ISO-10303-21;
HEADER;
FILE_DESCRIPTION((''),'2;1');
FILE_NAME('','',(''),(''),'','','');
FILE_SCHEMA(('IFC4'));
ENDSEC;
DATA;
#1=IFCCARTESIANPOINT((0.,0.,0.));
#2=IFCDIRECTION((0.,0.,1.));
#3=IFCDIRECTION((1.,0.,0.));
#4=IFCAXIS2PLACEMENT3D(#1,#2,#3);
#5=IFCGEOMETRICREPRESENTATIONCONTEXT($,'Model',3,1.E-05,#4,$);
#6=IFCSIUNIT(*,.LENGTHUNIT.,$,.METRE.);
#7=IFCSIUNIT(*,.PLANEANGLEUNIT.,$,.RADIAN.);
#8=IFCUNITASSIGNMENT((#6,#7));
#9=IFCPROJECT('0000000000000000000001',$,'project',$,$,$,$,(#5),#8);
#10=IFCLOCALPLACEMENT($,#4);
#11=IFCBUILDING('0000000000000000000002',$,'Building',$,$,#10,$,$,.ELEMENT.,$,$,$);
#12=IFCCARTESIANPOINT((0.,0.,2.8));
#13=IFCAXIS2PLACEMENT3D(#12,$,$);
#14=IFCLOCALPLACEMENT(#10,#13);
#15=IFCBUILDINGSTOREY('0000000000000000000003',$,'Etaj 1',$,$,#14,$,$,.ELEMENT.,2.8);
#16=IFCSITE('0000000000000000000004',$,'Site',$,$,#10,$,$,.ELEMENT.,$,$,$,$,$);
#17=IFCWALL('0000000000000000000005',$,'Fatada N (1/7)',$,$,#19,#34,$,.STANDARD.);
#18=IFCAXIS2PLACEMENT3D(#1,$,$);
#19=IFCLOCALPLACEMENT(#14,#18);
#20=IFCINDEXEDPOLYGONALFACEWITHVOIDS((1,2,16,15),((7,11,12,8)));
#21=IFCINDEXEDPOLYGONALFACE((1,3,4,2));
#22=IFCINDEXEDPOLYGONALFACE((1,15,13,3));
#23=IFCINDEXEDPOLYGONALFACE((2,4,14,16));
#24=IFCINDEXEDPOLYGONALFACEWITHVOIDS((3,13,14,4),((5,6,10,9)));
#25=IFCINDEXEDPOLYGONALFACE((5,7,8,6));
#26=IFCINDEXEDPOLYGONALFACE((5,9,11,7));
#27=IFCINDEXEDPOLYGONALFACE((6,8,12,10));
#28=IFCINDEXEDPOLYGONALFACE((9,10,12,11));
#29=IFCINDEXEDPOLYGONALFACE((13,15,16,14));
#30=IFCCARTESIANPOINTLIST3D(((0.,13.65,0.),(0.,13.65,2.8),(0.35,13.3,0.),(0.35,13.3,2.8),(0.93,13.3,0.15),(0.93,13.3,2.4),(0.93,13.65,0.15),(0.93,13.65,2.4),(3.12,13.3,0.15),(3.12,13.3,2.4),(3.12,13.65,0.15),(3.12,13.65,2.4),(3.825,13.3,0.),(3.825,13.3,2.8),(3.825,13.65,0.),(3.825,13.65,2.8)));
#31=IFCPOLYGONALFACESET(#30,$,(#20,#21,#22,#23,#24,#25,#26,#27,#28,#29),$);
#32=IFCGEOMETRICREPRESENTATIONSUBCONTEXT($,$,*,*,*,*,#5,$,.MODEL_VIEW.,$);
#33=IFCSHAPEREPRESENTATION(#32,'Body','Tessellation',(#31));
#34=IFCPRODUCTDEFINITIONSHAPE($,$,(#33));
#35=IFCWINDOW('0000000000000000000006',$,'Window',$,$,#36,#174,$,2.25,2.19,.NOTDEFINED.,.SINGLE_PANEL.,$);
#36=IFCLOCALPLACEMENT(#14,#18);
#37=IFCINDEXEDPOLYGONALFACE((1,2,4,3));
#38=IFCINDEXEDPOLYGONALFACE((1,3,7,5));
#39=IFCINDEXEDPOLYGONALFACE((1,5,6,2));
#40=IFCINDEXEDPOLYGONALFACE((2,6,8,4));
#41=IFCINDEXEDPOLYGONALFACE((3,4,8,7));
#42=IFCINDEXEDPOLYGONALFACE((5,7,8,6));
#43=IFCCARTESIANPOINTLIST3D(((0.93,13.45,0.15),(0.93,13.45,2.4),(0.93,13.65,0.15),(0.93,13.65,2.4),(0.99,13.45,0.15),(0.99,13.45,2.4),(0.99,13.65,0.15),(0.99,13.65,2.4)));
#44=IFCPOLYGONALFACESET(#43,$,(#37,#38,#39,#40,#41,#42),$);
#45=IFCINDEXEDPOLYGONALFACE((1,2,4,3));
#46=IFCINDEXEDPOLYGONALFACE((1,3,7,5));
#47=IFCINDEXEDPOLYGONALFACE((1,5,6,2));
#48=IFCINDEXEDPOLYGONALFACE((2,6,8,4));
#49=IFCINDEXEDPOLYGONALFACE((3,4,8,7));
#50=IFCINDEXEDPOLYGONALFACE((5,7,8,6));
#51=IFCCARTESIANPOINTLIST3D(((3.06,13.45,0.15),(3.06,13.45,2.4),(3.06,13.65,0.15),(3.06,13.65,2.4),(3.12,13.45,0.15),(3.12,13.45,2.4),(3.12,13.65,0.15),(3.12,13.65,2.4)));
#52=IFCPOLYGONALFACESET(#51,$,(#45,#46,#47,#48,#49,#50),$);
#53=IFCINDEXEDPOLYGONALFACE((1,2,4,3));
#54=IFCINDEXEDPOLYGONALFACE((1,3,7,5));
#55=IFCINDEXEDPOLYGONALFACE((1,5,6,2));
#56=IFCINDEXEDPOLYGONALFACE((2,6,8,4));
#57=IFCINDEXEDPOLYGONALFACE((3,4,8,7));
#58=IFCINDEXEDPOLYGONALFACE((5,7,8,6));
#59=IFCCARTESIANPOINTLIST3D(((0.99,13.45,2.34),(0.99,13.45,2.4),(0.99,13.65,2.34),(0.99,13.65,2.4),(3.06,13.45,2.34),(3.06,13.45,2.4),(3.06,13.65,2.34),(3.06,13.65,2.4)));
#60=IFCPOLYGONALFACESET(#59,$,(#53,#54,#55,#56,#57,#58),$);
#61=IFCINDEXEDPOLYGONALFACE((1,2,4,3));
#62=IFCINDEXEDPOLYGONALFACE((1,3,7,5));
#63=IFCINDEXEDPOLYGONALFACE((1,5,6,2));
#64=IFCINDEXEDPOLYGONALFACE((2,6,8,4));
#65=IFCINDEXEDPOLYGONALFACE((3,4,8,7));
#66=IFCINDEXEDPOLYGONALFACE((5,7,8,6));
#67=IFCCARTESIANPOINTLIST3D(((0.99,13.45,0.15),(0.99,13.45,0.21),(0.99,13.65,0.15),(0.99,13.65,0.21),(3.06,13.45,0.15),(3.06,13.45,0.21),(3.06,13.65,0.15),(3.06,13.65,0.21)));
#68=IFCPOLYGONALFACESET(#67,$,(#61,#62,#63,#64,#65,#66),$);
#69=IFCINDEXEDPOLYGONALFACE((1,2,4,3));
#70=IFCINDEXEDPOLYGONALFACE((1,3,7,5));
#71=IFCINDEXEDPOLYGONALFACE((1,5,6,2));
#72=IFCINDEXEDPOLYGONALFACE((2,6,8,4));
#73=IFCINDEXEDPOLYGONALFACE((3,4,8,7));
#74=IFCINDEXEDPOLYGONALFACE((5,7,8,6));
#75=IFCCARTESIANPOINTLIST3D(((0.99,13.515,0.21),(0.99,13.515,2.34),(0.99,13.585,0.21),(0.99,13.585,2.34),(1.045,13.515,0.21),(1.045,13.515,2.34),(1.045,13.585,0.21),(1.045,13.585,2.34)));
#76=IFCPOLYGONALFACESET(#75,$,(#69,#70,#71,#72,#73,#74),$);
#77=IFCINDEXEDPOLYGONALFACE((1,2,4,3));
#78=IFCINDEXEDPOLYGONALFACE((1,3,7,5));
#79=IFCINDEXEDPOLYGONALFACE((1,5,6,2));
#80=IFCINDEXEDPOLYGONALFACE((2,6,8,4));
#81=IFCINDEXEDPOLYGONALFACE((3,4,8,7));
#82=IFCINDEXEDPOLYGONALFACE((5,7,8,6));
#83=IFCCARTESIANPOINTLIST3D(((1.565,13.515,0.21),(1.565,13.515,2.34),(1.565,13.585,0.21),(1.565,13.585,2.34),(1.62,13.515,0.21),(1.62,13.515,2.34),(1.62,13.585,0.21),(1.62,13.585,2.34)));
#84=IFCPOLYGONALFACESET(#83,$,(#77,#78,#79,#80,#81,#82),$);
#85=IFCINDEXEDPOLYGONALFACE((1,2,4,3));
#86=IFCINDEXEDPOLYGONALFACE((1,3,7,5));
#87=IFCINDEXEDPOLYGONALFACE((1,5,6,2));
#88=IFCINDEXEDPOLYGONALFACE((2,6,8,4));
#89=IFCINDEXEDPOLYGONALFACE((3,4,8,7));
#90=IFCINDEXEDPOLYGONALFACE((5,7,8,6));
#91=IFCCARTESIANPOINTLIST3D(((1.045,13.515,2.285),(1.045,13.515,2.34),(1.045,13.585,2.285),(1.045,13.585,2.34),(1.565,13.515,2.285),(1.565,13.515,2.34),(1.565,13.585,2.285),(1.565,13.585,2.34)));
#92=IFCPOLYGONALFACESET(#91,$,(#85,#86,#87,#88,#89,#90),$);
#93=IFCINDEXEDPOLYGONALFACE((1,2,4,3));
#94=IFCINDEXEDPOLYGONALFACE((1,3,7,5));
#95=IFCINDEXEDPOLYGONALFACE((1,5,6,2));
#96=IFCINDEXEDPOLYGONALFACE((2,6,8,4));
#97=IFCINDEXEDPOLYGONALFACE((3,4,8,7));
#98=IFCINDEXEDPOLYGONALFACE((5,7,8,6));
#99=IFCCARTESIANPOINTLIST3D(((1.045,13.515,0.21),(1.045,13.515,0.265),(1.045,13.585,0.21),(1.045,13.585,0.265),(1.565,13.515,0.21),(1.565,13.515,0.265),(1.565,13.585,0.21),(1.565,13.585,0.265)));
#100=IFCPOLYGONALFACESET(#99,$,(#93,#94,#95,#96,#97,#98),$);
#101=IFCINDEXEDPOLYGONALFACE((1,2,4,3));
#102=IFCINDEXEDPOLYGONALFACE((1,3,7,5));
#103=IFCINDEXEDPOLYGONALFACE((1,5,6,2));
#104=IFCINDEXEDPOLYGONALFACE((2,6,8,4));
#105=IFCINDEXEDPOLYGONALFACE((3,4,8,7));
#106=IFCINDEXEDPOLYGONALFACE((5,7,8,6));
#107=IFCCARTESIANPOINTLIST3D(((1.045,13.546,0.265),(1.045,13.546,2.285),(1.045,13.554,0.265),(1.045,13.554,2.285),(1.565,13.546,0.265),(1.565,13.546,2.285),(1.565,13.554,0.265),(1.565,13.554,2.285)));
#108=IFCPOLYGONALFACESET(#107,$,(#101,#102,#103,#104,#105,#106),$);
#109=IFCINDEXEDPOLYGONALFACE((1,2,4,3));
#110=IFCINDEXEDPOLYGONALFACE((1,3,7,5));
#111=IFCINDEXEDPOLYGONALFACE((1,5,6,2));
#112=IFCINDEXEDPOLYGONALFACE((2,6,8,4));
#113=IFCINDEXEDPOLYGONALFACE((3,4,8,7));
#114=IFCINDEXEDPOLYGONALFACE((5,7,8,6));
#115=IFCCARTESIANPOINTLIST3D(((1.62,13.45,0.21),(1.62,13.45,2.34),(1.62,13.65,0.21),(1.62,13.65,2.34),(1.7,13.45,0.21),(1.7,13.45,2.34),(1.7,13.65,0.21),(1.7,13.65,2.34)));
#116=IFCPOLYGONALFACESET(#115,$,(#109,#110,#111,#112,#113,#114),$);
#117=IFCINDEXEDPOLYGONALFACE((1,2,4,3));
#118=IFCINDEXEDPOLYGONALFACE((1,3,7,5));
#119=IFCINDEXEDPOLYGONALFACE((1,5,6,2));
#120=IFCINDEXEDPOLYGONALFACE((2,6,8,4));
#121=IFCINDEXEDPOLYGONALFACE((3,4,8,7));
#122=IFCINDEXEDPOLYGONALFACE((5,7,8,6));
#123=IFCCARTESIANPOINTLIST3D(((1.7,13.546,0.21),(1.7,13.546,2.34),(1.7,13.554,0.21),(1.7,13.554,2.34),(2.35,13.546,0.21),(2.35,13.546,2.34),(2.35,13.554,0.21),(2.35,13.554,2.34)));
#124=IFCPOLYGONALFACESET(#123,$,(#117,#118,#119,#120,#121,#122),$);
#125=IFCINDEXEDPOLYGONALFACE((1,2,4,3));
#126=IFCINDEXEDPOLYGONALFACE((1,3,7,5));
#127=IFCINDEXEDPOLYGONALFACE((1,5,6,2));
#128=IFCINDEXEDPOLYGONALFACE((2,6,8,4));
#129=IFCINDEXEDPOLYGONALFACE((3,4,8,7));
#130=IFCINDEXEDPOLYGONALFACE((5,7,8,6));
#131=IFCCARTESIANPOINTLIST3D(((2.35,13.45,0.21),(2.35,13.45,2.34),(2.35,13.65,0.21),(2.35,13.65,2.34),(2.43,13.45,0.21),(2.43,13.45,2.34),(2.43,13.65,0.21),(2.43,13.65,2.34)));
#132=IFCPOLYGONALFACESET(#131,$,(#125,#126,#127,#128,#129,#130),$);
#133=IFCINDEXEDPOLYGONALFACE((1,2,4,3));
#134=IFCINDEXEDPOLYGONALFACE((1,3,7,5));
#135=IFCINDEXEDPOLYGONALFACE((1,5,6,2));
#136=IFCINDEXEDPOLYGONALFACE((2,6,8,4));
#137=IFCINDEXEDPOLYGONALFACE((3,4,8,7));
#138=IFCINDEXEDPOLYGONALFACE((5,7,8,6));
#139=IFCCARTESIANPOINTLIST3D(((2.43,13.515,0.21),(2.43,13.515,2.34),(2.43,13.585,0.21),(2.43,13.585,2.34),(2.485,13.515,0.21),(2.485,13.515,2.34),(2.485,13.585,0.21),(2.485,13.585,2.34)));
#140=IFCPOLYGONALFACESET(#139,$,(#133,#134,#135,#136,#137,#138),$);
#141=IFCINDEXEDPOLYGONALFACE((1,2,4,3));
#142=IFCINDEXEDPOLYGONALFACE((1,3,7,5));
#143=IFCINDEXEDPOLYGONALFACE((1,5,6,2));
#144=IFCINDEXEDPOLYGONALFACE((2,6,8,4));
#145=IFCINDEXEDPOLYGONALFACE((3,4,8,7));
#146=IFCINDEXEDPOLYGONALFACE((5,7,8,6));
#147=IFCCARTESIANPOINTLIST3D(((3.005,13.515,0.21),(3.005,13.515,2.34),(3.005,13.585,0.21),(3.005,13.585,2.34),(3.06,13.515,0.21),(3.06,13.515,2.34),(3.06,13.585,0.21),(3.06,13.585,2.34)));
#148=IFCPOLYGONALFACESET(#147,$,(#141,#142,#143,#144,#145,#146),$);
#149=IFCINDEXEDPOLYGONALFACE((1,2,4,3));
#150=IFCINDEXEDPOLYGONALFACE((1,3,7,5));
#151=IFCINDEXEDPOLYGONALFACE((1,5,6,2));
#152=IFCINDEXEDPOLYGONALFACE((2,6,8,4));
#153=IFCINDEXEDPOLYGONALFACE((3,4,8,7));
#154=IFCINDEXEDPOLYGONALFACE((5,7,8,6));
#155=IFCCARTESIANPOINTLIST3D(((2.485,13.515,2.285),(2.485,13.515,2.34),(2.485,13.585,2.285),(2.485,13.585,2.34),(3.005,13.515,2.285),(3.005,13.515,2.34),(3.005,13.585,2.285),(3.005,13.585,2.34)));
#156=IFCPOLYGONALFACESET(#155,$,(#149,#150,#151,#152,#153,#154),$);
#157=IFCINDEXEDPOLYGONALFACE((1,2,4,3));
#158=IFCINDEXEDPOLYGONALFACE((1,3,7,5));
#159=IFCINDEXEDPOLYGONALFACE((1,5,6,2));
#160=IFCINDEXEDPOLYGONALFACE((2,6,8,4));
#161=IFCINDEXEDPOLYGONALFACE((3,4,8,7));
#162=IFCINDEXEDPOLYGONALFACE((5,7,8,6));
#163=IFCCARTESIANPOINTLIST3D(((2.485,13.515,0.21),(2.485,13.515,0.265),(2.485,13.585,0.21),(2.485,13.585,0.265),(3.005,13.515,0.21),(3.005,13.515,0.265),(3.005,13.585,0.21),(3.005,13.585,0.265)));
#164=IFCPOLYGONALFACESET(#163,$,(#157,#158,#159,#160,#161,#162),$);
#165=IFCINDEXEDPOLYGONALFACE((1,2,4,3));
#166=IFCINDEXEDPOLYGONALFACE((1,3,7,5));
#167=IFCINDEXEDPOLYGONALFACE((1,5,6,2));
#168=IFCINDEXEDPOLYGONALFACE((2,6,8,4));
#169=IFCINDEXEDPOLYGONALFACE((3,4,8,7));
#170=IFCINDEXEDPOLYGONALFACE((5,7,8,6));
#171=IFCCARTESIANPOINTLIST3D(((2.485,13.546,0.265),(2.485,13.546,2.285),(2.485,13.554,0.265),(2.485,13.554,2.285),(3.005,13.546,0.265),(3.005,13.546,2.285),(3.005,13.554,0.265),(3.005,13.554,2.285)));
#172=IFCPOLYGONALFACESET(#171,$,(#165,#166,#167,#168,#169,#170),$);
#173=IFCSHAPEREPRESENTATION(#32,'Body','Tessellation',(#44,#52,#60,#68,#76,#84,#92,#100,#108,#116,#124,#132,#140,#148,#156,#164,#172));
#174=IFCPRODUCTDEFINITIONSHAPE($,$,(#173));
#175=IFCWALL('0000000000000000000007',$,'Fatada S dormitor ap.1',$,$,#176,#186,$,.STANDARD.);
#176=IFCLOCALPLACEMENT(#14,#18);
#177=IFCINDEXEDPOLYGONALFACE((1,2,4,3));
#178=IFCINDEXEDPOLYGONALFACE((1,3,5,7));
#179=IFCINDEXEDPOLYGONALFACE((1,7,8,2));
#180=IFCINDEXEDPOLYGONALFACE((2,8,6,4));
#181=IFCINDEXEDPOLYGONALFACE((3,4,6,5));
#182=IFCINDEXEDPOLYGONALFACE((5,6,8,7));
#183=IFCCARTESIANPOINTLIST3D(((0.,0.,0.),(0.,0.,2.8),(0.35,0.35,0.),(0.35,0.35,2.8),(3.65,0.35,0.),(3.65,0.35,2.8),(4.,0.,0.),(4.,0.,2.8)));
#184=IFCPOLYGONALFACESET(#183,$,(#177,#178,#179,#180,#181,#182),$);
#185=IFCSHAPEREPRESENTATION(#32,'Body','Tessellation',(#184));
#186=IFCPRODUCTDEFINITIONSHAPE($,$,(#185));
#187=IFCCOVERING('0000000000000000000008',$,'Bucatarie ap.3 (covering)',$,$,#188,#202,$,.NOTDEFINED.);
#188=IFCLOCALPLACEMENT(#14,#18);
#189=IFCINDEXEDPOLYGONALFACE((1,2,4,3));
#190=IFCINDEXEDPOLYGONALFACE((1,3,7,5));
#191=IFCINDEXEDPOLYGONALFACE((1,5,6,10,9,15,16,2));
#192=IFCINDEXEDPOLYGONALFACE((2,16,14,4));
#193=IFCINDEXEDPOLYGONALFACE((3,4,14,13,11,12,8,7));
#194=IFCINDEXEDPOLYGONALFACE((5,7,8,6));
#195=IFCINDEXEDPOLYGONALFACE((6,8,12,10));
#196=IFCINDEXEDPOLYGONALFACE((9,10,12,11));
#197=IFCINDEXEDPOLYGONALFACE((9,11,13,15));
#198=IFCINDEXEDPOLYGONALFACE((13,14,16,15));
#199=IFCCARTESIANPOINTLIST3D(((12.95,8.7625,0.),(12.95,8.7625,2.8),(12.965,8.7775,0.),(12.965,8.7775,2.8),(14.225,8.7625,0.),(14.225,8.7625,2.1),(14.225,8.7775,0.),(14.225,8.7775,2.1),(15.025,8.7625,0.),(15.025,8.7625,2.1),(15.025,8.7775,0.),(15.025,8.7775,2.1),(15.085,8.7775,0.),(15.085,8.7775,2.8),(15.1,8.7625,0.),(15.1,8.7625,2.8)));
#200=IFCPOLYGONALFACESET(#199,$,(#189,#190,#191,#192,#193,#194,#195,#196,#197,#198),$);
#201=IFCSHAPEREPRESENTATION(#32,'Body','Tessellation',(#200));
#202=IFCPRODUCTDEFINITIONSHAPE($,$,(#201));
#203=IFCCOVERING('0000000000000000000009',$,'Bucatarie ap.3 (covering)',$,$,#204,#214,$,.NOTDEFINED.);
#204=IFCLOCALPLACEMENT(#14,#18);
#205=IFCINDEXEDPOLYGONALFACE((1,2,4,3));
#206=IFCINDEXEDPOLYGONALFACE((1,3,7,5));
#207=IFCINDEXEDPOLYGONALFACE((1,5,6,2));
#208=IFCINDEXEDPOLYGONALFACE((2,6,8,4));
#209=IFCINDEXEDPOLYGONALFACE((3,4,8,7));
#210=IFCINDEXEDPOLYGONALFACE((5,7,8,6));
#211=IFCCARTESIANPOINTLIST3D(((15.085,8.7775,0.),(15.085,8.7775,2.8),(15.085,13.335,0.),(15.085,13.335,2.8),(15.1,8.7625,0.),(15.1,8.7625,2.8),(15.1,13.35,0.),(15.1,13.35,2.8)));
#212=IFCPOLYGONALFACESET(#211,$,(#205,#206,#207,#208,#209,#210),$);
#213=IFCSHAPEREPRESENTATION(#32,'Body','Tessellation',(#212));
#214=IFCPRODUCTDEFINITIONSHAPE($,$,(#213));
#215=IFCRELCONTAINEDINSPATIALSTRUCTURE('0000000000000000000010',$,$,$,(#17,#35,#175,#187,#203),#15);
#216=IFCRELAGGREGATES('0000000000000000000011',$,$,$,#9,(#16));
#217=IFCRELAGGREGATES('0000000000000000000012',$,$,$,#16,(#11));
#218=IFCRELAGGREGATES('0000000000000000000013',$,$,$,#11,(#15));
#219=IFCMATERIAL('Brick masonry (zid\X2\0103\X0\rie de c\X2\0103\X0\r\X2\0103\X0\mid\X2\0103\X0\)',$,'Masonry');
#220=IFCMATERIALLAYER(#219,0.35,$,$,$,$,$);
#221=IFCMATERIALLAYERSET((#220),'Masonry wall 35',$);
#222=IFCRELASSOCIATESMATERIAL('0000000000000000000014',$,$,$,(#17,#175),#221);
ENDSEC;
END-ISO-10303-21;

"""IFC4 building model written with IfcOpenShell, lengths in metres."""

from ifc_helpers import new_model, si_unit, frame, frame_2d, origin, origin_with_axes, origin_2d, place, context, subcontext, project, spatial, polyline, rectangle, outline, extrude, clip, halfspace, material, layer, layer_set, layer_usage, element, fill, save


model = new_model("IFC4")

# Units and contexts
model_context = context("Model", 3, precision=1e-05, world=origin_with_axes())
sub_context = subcontext(model_context, None, None, "MODEL_VIEW")
ifc_project = project(units=[si_unit("LENGTHUNIT", "METRE"), si_unit("PLANEANGLEUNIT", "RADIAN")], contexts=[model_context])

# Site, building, storey
placement = place(None, origin_with_axes())
site = spatial("IfcSite", under=ifc_project, at=placement, Name="Site", CompositionType="ELEMENT")
building = spatial("IfcBuilding", under=site, at=placement, Name="Building", CompositionType="ELEMENT")
storey_placement = place(placement, frame((0.0, 0.0, 2.8)))
storey = spatial("IfcBuildingStorey", under=building, at=storey_placement, Name="Etaj 1", CompositionType="ELEMENT", Elevation=2.8)

# Wall, opening, window
ifc_material = material(Name="Brick masonry (zidărie de cărămidă)", Category="Masonry")
ifc_layer = layer(ifc_material, 0.35)
ifc_layer_set = layer_set([ifc_layer], Name="Masonry wall 35")
ifc_layer_usage = layer_usage(ifc_layer_set, "AXIS2", "POSITIVE", -0.175)
wall_1_placement = place(storey_placement, frame((0.0, 13.475, 0.0), x_axis=(1.0, 0.0, 0.0)))
wall_1 = element("IfcWall", 1, at=wall_1_placement, inside=storey, material=ifc_layer_usage, Name="Fatada N (1/7)", PredefinedType="STANDARD", context=sub_context, shape_type="CSG", body=[
    clip(extrude(rectangle(XDim=3.825, YDim=0.35, at=frame_2d((1.9125, 0.0))), origin(), (0.0, 0.0, 1.0), 2.8), halfspace(frame((0.175, 0.0, 0.0), z_axis=(-0.707107, -0.707107, 0.0)), False)),
])
opening_1_placement = place(wall_1_placement, frame((2.025, 0.225, 0.15), z_axis=(0.0, -1.0, 0.0), x_axis=(1.0, 0.0, 0.0)))
opening_1 = element("IfcOpeningElement", 2, at=opening_1_placement, cuts=wall_1, PredefinedType="OPENING", context=sub_context, shape_type="SweptSolid", body=[
    extrude(rectangle(XDim=2.19, YDim=2.25, at=frame_2d((0.0, 1.125))), origin(), (0.0, 0.0, 1.0), 0.45),
])
window_placement = place(wall_1_placement, frame((2.025, 0.175, 0.15), z_axis=(0.0, -1.0, 0.0), x_axis=(1.0, 0.0, 0.0)))
window = element("IfcWindow", 3, at=window_placement, inside=storey, Name="Window", OverallHeight=2.25, OverallWidth=2.19, PartitioningType="SINGLE_PANEL", PredefinedType="NOTDEFINED", context=sub_context, shape_type="SweptSolid", body=[
    extrude(rectangle(XDim=0.06, YDim=2.25, at=origin_2d()), frame((-1.065, 1.125, 0.0)), (0.0, 0.0, 1.0), 0.2),
    extrude(rectangle(XDim=0.06, YDim=2.25, at=origin_2d()), frame((1.065, 1.125, 0.0)), (0.0, 0.0, 1.0), 0.2),
    extrude(rectangle(XDim=2.07, YDim=0.06, at=origin_2d()), frame((0.0, 2.22, 0.0)), (0.0, 0.0, 1.0), 0.2),
    extrude(rectangle(XDim=2.07, YDim=0.06, at=origin_2d()), frame((0.0, 0.03, 0.0)), (0.0, 0.0, 1.0), 0.2),
    extrude(rectangle(XDim=0.055, YDim=2.13, at=origin_2d()), frame((-1.0075, 1.125, 0.065)), (0.0, 0.0, 1.0), 0.07),
    extrude(rectangle(XDim=0.055, YDim=2.13, at=origin_2d()), frame((-0.4325, 1.125, 0.065)), (0.0, 0.0, 1.0), 0.07),
    extrude(rectangle(XDim=0.52, YDim=0.055, at=origin_2d()), frame((-0.72, 2.1625, 0.065)), (0.0, 0.0, 1.0), 0.07),
    extrude(rectangle(XDim=0.52, YDim=0.055, at=origin_2d()), frame((-0.72, 0.0875, 0.065)), (0.0, 0.0, 1.0), 0.07),
    extrude(rectangle(XDim=0.52, YDim=2.02, at=origin_2d()), frame((-0.72, 1.125, 0.096)), (0.0, 0.0, 1.0), 0.008),
    extrude(rectangle(XDim=0.08, YDim=2.13, at=origin_2d()), frame((-0.365, 1.125, 0.0)), (0.0, 0.0, 1.0), 0.2),
    extrude(rectangle(XDim=0.65, YDim=2.13, at=origin_2d()), frame((0.0, 1.125, 0.096)), (0.0, 0.0, 1.0), 0.008),
    extrude(rectangle(XDim=0.08, YDim=2.13, at=origin_2d()), frame((0.365, 1.125, 0.0)), (0.0, 0.0, 1.0), 0.2),
    extrude(rectangle(XDim=0.055, YDim=2.13, at=origin_2d()), frame((0.4325, 1.125, 0.065)), (0.0, 0.0, 1.0), 0.07),
    extrude(rectangle(XDim=0.055, YDim=2.13, at=origin_2d()), frame((1.0075, 1.125, 0.065)), (0.0, 0.0, 1.0), 0.07),
    extrude(rectangle(XDim=0.52, YDim=0.055, at=origin_2d()), frame((0.72, 2.1625, 0.065)), (0.0, 0.0, 1.0), 0.07),
    extrude(rectangle(XDim=0.52, YDim=0.055, at=origin_2d()), frame((0.72, 0.0875, 0.065)), (0.0, 0.0, 1.0), 0.07),
    extrude(rectangle(XDim=0.52, YDim=2.02, at=origin_2d()), frame((0.72, 1.125, 0.096)), (0.0, 0.0, 1.0), 0.008),
])
fill(opening_1, window)

# Wall
wall_2_placement = place(storey_placement, frame((0.0, 0.175, 0.0), x_axis=(1.0, 0.0, 0.0)))
element("IfcWall", 4, at=wall_2_placement, inside=storey, material=ifc_layer_usage, Name="Fatada S dormitor ap.1", PredefinedType="STANDARD", context=sub_context, shape_type="CSG", body=[
    clip(clip(extrude(rectangle(XDim=4.0, YDim=0.35, at=frame_2d((2.0, 0.0))), origin(), (0.0, 0.0, 1.0), 2.8), halfspace(frame((0.175, 0.0, 0.0), z_axis=(-0.707107, 0.707107, 0.0)), False)), halfspace(frame((3.825, 0.0, 0.0), z_axis=(0.707107, 0.707107, 0.0)), False)),
])

# Covering, opening
covering_1_placement = place(storey_placement, origin_with_axes())
covering_1 = element("IfcCovering", 5, at=covering_1_placement, inside=storey, Name="Bucatarie ap.3 (covering)", PredefinedType="NOTDEFINED", context=sub_context, shape_type="SweptSolid", body=[
    extrude(outline(polyline([(12.95, 8.7625), (15.1, 8.7625), (15.085, 8.7775), (12.965, 8.7775), (12.95, 8.7625)])), origin(), (0.0, 0.0, 1.0), 2.8),
])
opening_2_placement = place(covering_1_placement, frame((14.625, 8.8275, 0.0), z_axis=(0.0, -1.0, 0.0), x_axis=(1.0, 0.0, 0.0)))
element("IfcOpeningElement", 6, at=opening_2_placement, cuts=covering_1, PredefinedType="OPENING", context=sub_context, shape_type="SweptSolid", body=[
    extrude(rectangle(XDim=0.8, YDim=2.1, at=origin_2d()), frame((0.0, 1.05, 0.0)), (0.0, 0.0, 1.0), 0.38),
])

# Covering
covering_2_placement = place(storey_placement, origin_with_axes())
element("IfcCovering", 7, at=covering_2_placement, inside=storey, Name="Bucatarie ap.3 (covering)", PredefinedType="NOTDEFINED", context=sub_context, shape_type="SweptSolid", body=[
    extrude(outline(polyline([(15.1, 8.7625), (15.1, 13.35), (15.085, 13.335), (15.085, 8.7775), (15.1, 8.7625)])), origin(), (0.0, 0.0, 1.0), 2.8),
])

save(model, "model.ifc")
